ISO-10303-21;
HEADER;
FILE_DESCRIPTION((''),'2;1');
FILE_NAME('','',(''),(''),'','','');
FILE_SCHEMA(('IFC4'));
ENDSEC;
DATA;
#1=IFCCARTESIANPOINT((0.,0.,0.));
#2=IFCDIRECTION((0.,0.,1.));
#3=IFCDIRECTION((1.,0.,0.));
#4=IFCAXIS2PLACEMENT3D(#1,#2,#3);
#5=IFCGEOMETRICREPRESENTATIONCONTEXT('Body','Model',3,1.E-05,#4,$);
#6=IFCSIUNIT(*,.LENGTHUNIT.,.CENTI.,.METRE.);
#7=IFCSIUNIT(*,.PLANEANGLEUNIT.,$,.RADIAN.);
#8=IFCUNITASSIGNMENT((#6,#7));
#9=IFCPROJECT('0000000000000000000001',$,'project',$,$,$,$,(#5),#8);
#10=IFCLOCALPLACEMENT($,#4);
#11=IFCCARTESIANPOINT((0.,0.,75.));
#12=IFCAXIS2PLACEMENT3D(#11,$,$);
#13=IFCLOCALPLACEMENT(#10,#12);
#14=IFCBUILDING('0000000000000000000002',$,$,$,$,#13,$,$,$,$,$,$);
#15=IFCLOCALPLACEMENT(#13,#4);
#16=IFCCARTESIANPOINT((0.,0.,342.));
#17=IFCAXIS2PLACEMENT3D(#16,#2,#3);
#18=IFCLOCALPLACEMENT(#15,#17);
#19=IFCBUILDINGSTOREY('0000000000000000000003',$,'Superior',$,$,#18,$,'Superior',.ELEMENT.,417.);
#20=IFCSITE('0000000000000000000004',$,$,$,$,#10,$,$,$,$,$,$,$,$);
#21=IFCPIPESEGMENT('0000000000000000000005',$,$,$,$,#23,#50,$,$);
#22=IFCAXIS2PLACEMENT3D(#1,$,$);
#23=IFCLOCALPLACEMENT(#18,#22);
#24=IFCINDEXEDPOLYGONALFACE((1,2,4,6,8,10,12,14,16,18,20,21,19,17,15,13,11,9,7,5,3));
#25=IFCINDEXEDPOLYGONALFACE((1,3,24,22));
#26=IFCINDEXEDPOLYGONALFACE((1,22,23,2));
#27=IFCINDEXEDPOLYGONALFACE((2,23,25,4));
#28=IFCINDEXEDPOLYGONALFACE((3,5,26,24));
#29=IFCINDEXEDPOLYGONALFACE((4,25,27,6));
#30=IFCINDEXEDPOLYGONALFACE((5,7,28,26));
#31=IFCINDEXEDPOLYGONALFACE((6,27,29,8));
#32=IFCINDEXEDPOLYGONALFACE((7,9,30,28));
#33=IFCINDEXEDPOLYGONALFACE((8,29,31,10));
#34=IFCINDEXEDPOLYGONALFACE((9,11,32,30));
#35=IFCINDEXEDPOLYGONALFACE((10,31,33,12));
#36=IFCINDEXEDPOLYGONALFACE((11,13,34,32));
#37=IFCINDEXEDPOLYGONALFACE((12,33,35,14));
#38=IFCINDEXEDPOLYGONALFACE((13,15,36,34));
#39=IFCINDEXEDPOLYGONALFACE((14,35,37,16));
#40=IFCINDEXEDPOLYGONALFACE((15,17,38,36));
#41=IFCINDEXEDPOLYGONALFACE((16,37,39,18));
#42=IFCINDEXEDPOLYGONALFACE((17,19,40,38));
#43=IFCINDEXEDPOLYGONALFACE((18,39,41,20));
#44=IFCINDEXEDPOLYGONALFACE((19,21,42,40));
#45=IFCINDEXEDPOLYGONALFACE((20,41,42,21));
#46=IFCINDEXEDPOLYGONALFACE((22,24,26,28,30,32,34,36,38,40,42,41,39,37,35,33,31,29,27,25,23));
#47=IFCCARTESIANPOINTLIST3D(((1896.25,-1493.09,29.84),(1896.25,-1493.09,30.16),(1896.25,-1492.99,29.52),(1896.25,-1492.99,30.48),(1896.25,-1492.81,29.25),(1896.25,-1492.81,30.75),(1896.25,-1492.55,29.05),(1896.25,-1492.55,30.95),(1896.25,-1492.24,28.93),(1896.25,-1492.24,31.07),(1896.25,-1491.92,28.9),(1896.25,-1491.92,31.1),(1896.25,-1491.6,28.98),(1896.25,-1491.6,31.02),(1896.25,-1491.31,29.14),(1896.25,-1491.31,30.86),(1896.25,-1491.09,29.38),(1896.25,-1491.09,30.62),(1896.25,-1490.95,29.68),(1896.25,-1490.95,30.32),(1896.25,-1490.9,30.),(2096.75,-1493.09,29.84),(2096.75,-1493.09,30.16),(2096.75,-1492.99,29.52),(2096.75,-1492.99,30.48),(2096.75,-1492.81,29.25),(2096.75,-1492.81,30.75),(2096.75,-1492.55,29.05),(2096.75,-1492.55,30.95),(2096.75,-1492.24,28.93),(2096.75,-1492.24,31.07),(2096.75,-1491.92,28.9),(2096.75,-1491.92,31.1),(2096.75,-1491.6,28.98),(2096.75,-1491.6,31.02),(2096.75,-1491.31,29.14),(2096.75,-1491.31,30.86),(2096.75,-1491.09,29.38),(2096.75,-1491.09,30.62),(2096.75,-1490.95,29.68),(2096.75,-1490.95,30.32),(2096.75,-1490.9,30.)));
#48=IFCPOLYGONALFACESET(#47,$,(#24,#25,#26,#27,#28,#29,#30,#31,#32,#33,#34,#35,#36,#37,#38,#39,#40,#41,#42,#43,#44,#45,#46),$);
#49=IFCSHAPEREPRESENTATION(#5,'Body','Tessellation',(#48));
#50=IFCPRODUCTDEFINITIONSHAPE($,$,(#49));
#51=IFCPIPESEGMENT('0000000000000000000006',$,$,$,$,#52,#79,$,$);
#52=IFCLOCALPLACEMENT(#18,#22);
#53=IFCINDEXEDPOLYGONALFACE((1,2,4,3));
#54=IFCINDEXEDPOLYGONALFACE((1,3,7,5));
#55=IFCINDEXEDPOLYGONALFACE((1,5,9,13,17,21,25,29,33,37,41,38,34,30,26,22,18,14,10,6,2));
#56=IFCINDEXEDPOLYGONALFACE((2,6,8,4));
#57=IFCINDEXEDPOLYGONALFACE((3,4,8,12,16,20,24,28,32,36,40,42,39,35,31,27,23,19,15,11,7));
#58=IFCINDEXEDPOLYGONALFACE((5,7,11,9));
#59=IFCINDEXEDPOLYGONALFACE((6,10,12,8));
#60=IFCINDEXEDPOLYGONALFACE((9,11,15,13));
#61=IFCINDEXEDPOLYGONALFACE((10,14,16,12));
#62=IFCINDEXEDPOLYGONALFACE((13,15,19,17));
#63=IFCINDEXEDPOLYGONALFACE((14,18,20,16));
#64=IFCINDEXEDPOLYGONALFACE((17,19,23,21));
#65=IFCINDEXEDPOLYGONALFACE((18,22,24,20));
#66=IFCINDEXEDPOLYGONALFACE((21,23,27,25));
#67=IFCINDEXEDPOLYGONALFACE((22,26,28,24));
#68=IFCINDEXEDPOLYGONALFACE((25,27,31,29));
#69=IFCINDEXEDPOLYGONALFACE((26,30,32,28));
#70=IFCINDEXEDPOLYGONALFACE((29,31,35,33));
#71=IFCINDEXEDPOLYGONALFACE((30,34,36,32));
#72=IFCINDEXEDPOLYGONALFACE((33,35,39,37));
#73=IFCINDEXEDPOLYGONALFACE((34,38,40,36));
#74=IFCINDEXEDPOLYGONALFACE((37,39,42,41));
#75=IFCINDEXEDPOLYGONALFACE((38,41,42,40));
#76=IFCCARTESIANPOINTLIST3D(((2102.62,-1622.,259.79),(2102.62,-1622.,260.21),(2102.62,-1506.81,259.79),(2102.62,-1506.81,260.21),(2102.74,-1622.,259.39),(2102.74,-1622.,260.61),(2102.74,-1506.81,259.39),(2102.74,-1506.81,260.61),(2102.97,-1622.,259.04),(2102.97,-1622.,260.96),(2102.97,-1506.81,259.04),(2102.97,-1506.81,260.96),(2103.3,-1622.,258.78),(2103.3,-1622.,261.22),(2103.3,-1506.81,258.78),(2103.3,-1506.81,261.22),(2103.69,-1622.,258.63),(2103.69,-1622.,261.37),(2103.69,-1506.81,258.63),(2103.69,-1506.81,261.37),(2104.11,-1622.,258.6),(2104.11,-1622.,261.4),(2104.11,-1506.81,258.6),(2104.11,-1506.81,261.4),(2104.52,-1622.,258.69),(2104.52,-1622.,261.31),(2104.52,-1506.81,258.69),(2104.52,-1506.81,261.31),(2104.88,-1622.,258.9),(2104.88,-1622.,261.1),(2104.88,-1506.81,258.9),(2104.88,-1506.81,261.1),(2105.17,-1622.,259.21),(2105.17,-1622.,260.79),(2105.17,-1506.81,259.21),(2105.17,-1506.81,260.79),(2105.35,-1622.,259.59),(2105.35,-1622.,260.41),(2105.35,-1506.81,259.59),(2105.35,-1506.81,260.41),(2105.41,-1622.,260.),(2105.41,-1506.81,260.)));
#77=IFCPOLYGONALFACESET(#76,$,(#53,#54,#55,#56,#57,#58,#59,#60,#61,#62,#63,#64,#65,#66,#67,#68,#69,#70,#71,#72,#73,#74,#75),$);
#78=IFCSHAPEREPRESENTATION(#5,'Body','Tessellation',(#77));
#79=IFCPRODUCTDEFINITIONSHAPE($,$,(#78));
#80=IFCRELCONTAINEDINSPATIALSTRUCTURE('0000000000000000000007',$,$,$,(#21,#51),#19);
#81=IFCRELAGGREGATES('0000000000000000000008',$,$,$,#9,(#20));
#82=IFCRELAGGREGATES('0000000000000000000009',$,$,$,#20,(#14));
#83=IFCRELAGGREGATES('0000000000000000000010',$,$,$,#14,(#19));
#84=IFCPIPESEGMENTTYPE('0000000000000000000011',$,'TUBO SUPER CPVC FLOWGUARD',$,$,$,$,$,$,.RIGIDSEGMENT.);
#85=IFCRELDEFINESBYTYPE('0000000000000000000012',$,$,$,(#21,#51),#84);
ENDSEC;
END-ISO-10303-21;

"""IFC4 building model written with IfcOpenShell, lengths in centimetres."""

from ifc_helpers import new_model, si_unit, frame, origin_with_axes, origin_2d_with_axis, place, context, project, spatial, circle, extrude, type_object, element, save


model = new_model("IFC4")

# Units and contexts
model_context = context("Model", 3, precision=1e-05, world=origin_with_axes(), identifier="Body")
ifc_project = project(units=[si_unit("LENGTHUNIT", "METRE", prefix="CENTI"), si_unit("PLANEANGLEUNIT", "RADIAN")], contexts=[model_context])

# Site, building, storey
site_placement = place(None, origin_with_axes())
site = spatial("IfcSite", under=ifc_project, at=site_placement)
building_placement = place(site_placement, frame((0.0, 0.0, 75.0)))
building = spatial("IfcBuilding", under=site, at=building_placement)
placement = place(building_placement, origin_with_axes())
storey_placement = place(placement, frame((0.0, 0.0, 342.0), z_axis=(0.0, 0.0, 1.0), x_axis=(1.0, 0.0, 0.0)))
storey = spatial("IfcBuildingStorey", under=building, at=storey_placement, Name="Superior", LongName="Superior", CompositionType="ELEMENT", Elevation=417.0)

# Pipe segments
pipe_segment_type_1 = type_object("IfcPipeSegmentType", Name="TUBO SUPER CPVC FLOWGUARD", PredefinedType="RIGIDSEGMENT")
pipe_segment_1_placement = place(storey_placement, frame((1996.5, -1492.0, 31.1), z_axis=(0.0, 0.0, 1.0), x_axis=(1.0, 0.0, 0.0)))
element("IfcPipeSegment", 1, at=pipe_segment_1_placement, inside=storey, type_object=pipe_segment_type_1, context=model_context, shape_type="SolidModel", body=[
    extrude(circle(Radius=1.1, at=origin_2d_with_axis()), frame((100.25, 0.0, -1.1), z_axis=(-1.0, 0.0, 0.0), x_axis=(0.0, 1.0, 0.0)), (0.0, 0.0, 1.0), 200.5),
])
pipe_segment_2_placement = place(storey_placement, frame((2104.0, -1564.4, 261.4), z_axis=(0.0, 0.0, 1.0), x_axis=(1.0, 0.0, 0.0)))
element("IfcPipeSegment", 2, at=pipe_segment_2_placement, inside=storey, type_object=pipe_segment_type_1, context=model_context, shape_type="SolidModel", body=[
    extrude(circle(Radius=1.41, at=origin_2d_with_axis()), frame((0.0, -57.6, -1.41), z_axis=(0.0, 1.0, 0.0), x_axis=(1.0, 0.0, 0.0)), (0.0, 0.0, 1.0), 115.19),
])

save(model, "model.ifc")
